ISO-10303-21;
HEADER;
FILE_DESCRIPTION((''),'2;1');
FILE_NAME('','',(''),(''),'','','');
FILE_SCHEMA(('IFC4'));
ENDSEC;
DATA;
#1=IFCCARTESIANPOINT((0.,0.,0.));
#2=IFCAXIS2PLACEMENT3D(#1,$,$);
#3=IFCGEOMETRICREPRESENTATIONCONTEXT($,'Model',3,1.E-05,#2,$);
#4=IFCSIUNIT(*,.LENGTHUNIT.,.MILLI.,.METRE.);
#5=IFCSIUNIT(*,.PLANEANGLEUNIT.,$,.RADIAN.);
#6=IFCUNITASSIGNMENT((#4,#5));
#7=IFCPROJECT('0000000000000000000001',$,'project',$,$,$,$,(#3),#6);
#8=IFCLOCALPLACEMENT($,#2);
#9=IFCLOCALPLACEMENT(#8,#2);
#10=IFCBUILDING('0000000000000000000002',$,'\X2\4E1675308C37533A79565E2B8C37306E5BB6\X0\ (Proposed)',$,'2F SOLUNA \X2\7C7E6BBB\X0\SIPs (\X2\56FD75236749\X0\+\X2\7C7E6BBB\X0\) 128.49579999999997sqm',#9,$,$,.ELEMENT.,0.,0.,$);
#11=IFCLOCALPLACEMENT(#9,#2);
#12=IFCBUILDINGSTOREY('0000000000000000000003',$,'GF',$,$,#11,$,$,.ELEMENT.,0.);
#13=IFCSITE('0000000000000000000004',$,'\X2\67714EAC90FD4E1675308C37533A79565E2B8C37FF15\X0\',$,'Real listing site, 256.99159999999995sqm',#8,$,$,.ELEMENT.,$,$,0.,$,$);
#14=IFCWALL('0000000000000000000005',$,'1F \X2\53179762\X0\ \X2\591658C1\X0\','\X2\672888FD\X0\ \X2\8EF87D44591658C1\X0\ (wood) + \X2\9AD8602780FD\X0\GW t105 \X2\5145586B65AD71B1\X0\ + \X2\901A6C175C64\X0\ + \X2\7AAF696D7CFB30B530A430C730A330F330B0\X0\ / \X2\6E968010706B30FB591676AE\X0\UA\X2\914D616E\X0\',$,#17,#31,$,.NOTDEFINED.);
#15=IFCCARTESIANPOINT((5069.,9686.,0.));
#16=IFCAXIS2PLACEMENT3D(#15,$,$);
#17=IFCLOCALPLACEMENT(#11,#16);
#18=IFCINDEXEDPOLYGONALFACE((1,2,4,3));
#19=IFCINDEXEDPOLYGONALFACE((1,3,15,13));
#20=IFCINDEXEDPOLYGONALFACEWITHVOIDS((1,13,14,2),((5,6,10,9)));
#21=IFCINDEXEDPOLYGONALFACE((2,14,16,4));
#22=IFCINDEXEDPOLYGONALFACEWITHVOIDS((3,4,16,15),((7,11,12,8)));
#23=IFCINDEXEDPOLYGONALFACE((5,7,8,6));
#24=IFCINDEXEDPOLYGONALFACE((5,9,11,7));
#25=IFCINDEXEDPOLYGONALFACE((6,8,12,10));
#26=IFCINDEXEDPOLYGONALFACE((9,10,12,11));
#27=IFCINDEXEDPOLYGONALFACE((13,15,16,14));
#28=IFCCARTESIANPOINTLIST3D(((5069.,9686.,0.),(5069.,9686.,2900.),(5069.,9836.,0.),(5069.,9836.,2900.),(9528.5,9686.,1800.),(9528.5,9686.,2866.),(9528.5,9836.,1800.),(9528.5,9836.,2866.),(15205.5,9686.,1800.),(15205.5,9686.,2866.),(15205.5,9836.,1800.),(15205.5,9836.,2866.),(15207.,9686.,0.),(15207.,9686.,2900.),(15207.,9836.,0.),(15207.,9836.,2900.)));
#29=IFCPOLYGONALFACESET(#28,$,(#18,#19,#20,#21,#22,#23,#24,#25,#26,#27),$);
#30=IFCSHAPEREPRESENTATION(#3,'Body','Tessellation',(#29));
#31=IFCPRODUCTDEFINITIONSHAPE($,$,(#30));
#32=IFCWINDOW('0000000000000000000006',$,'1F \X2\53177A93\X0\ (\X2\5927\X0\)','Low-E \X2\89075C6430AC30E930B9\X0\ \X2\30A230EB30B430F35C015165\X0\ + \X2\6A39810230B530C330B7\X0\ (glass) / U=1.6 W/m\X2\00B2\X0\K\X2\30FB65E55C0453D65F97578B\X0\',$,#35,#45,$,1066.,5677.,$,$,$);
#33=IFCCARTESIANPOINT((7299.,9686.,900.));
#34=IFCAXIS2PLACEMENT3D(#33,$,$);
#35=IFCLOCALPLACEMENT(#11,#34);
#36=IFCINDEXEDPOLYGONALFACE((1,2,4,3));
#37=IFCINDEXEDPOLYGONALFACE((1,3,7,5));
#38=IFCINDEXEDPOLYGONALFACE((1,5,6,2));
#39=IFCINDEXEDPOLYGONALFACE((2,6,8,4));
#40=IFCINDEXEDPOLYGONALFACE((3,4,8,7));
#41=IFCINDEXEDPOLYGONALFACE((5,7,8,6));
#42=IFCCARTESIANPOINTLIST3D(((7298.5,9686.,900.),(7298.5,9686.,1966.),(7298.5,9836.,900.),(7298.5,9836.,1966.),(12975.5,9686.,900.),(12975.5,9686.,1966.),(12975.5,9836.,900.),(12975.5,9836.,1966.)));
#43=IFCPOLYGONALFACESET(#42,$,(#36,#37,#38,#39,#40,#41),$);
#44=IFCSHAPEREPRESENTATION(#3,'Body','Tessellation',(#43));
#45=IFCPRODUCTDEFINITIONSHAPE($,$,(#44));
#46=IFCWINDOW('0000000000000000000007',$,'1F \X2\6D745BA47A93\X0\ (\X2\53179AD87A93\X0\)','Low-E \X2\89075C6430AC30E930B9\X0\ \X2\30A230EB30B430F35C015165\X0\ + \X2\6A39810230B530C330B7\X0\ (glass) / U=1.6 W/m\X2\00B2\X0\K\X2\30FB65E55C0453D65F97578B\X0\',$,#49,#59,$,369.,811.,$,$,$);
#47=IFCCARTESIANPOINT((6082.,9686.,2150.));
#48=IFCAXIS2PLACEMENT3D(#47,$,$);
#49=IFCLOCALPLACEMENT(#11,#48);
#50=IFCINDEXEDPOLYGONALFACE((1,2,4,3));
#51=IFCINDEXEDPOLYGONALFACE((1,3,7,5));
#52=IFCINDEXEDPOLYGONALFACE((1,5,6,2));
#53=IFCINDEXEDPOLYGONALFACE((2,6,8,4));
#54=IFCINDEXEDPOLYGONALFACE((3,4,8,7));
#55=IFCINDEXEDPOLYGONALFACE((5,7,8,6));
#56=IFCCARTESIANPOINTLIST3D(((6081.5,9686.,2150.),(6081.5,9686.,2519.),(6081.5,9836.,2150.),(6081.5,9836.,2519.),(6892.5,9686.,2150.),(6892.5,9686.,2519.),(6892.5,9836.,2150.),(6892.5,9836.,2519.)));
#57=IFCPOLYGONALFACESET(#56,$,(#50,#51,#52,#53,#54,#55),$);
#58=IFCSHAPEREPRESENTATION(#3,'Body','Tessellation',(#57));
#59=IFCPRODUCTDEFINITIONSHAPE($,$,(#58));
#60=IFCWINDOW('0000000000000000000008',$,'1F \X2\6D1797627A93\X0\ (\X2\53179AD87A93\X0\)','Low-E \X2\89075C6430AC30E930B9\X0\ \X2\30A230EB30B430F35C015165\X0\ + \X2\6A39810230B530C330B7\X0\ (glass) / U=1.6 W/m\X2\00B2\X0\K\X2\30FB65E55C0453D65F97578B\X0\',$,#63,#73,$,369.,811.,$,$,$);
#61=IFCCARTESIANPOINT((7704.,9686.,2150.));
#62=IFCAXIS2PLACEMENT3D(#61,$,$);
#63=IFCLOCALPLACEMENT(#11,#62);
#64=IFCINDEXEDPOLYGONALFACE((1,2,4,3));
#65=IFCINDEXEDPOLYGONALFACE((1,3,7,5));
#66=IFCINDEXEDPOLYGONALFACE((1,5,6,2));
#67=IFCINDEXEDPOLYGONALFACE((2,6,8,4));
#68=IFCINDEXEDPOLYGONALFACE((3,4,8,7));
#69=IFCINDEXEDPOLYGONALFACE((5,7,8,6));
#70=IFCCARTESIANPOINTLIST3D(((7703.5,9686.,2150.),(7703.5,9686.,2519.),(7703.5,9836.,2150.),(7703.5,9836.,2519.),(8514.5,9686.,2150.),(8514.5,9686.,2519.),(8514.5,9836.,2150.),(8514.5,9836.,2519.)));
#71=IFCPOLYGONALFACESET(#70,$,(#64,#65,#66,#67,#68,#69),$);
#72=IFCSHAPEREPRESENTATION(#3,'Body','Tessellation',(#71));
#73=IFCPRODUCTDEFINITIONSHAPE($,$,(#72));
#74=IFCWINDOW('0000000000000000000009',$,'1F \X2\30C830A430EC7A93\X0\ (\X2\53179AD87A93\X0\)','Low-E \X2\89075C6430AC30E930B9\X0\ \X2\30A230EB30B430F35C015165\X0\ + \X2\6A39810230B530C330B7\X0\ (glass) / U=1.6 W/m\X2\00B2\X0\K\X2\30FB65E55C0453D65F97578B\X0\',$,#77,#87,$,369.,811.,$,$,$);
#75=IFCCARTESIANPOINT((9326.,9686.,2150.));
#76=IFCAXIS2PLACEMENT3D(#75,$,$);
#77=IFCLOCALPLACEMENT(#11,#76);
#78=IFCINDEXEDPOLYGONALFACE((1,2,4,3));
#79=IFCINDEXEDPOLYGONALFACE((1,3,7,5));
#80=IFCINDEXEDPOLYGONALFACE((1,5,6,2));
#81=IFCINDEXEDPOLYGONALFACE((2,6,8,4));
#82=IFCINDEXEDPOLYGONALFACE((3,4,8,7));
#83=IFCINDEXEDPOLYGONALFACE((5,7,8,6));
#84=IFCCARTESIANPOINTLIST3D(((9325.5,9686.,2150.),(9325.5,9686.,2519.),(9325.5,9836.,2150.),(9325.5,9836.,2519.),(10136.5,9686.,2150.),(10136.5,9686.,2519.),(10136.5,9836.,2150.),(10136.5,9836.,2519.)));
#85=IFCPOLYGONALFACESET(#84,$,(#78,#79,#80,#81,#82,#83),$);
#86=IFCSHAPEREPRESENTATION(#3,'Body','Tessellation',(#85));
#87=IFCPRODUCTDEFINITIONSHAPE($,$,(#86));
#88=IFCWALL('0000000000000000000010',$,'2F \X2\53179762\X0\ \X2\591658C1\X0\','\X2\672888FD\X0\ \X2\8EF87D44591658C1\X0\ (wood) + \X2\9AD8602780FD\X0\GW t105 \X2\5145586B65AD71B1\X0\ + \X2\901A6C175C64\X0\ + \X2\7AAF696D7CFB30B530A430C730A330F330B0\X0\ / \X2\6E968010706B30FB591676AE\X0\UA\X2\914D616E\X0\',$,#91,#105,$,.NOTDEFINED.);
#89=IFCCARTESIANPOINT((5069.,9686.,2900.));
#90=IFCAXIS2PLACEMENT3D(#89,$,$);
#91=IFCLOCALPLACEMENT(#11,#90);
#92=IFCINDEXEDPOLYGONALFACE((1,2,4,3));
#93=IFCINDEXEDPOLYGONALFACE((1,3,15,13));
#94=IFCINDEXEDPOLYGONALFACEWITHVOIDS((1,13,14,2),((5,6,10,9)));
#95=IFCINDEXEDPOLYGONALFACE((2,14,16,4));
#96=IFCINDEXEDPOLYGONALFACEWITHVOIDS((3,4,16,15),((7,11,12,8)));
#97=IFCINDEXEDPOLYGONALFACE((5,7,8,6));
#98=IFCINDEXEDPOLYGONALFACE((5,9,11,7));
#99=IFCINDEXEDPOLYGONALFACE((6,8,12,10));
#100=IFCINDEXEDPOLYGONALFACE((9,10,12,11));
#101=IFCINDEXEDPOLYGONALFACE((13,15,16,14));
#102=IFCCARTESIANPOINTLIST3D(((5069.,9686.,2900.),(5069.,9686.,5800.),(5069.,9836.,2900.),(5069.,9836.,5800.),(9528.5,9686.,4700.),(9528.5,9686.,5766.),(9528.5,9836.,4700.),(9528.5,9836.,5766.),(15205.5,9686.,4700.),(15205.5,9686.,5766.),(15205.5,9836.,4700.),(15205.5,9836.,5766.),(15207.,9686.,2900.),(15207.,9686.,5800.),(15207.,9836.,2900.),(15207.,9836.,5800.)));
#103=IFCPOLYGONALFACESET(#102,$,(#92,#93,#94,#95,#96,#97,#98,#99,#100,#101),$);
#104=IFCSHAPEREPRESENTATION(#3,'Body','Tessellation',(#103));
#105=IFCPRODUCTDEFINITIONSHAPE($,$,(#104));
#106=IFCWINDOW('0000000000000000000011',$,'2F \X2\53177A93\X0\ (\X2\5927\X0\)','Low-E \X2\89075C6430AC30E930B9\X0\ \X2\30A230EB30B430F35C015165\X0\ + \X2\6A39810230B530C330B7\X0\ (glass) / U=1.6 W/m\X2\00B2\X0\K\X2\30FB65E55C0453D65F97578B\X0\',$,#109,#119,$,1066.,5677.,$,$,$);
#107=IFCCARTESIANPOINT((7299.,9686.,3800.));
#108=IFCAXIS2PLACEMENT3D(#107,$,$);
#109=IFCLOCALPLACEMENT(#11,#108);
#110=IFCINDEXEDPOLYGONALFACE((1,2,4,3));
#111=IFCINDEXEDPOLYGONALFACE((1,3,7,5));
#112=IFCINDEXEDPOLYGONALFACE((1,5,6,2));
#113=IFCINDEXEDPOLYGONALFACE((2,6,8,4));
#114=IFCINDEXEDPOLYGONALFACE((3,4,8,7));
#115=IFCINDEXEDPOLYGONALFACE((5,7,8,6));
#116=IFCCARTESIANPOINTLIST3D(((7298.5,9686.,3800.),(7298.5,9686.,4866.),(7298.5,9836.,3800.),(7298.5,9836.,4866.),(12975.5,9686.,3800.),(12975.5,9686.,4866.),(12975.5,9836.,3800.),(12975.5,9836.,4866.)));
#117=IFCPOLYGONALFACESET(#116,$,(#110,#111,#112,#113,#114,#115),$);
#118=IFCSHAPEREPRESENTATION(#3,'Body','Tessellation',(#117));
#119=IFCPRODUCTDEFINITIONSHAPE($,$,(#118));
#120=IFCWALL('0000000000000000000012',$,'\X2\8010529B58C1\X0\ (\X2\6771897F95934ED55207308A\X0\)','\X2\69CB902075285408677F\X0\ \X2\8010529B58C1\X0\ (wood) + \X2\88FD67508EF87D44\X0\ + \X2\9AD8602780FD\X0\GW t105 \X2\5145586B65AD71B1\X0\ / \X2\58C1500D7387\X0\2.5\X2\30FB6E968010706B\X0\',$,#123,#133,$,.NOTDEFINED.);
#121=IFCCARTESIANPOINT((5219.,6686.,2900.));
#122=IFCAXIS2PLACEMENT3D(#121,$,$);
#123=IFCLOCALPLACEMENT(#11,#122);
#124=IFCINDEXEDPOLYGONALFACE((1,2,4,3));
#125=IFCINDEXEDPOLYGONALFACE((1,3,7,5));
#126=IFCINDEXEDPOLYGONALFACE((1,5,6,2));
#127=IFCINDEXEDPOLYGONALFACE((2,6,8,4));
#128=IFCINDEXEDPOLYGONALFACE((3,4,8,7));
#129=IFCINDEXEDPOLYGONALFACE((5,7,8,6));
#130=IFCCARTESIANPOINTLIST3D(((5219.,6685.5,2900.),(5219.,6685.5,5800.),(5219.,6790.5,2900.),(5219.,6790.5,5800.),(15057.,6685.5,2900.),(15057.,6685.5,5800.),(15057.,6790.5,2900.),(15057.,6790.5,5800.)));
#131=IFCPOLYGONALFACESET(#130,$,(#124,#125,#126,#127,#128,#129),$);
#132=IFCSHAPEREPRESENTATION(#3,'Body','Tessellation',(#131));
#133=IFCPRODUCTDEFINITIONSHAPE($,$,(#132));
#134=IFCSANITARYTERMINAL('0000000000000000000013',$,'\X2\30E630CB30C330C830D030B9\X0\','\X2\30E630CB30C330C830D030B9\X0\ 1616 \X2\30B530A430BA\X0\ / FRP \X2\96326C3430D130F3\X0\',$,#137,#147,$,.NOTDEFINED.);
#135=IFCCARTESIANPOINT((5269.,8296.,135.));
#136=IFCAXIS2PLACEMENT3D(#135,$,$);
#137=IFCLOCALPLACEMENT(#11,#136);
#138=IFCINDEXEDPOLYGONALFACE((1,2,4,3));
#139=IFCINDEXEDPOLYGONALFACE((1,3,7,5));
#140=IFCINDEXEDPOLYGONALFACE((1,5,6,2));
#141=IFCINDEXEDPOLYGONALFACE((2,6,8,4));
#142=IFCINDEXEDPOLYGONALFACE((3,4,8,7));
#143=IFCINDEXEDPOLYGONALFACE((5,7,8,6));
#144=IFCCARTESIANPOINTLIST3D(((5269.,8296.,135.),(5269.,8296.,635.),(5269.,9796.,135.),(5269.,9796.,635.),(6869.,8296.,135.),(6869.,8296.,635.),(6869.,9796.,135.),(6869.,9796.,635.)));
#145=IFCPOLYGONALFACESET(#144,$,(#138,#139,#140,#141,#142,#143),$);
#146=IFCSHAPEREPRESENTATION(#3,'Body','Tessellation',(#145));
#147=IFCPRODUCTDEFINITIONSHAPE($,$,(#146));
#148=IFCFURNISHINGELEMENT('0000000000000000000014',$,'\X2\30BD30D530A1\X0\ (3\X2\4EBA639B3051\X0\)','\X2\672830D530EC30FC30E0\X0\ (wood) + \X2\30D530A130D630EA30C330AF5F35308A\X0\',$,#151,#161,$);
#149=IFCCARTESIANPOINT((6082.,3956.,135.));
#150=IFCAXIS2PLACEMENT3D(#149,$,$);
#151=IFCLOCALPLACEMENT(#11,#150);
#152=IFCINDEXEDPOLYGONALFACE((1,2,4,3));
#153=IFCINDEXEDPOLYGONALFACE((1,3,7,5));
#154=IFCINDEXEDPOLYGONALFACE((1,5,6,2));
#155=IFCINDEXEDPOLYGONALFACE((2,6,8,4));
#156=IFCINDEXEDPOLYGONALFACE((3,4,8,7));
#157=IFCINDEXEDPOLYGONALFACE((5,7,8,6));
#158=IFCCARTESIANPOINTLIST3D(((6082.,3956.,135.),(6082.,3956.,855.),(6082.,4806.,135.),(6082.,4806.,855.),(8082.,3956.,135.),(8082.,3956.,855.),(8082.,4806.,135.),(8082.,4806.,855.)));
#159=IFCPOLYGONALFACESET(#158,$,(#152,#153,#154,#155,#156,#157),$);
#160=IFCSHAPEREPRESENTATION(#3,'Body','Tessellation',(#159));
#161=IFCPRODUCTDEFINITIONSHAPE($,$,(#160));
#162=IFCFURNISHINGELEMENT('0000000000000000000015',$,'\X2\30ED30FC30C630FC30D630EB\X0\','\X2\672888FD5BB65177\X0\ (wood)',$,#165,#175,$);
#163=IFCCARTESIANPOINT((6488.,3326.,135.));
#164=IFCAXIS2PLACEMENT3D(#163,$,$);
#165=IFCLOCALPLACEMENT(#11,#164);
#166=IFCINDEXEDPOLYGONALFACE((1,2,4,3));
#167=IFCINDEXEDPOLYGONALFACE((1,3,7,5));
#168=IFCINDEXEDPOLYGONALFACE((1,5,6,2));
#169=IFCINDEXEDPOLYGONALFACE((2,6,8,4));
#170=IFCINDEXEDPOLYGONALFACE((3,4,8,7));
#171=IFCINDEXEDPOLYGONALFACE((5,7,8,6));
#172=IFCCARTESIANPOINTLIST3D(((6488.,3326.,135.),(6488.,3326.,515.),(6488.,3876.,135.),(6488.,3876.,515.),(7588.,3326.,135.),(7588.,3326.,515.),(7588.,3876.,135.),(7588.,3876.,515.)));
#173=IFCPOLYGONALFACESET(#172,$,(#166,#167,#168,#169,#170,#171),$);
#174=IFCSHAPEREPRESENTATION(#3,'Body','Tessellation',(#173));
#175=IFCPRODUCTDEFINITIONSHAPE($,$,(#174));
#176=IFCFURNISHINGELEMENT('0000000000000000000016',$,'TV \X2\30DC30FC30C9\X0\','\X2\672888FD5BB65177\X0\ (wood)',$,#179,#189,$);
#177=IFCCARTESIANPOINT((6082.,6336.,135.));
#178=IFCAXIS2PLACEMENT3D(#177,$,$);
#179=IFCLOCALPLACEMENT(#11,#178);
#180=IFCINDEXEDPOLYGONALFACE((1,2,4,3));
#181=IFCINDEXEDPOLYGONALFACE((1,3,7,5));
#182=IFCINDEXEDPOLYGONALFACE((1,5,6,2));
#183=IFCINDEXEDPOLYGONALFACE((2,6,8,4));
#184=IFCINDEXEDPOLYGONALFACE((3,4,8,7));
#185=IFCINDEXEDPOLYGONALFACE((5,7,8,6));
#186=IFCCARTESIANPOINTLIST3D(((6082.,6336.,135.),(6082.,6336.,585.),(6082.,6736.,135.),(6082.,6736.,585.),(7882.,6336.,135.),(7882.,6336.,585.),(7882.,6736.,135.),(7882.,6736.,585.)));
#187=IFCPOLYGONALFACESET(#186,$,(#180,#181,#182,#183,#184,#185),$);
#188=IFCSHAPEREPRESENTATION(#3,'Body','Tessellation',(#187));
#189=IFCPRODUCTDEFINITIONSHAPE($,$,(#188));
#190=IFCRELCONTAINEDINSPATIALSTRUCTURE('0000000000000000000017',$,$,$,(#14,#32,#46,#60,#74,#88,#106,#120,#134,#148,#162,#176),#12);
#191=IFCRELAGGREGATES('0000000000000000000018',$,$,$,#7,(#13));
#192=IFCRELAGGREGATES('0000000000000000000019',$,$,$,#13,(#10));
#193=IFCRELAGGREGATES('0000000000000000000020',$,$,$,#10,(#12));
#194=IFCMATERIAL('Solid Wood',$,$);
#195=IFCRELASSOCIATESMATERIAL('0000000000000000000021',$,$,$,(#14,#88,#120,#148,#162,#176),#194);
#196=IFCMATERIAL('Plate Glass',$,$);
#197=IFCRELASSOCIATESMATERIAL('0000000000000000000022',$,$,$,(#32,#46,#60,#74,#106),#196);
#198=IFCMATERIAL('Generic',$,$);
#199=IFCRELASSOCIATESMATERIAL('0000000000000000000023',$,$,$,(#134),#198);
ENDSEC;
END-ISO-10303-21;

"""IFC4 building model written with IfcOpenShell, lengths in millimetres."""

from ifc_helpers import new_model, si_unit, frame, frame_2d, origin, place, context, project, spatial, rectangle, extrude, material, element, fill, save


model = new_model("IFC4")

# Units and contexts
model_context = context("Model", 3, precision=1e-05, world=origin())
ifc_project = project(units=[si_unit("LENGTHUNIT", "METRE", prefix="MILLI"), si_unit("PLANEANGLEUNIT", "RADIAN")], contexts=[model_context])

# Site, building, storey
site_placement = place(None, origin())
site = spatial("IfcSite", under=ifc_project, at=site_placement, Name="東京都世田谷区祖師谷５", ObjectType="Real listing site, 256.99159999999995sqm", CompositionType="ELEMENT", RefElevation=0.0)
building_placement = place(site_placement, origin())
building = spatial("IfcBuilding", under=site, at=building_placement, Name="世田谷区祖師谷の家 (Proposed)", ObjectType="2F SOLUNA 籾殻SIPs (国産杉+籾殻) 128.49579999999997sqm", CompositionType="ELEMENT", ElevationOfRefHeight=0.0, ElevationOfTerrain=0.0)
storey_placement = place(building_placement, origin())
storey = spatial("IfcBuildingStorey", under=building, at=storey_placement, Name="GF", CompositionType="ELEMENT", Elevation=0.0)

# Wall, openings, windows
ifc_material_1 = material(Name="Solid Wood")
wall_1_placement = place(storey_placement, frame((5069.0, 9686.0, 0.0)))
wall_1 = element("IfcWall", 1, at=wall_1_placement, inside=storey, material=ifc_material_1, Name="1F 北面 外壁", Description="木製 軸組外壁 (wood) + 高性能GW t105 充填断熱 + 通気層 + 窯業系サイディング / 準耐火・外皮UA配慮", PredefinedType="NOTDEFINED", context=model_context, shape_type="SweptSolid", body=[
    extrude(rectangle(XDim=10138.0, YDim=150.0, at=frame_2d((5069.0, 75.0))), frame((5069.0, 9686.0, 0.0)), (0.0, 0.0, 1.0), 2900.0),
])
opening_1_placement = place(storey_placement, frame((7299.0, 9686.0, 900.0)))
opening_1 = element("IfcOpeningElement", 2, at=opening_1_placement, cuts=wall_1, PredefinedType="NOTDEFINED", context=model_context, shape_type="SweptSolid", body=[
    extrude(rectangle(XDim=5677.0, YDim=150.0, at=frame_2d((2838.0, 75.0))), frame((7299.0, 9686.0, 900.0)), (0.0, 0.0, 1.0), 1066.0),
])
opening_2_placement = place(storey_placement, frame((6082.0, 9686.0, 2150.0)))
opening_2 = element("IfcOpeningElement", 3, at=opening_2_placement, cuts=wall_1, PredefinedType="NOTDEFINED", context=model_context, shape_type="SweptSolid", body=[
    extrude(rectangle(XDim=811.0, YDim=150.0, at=frame_2d((405.0, 75.0))), frame((6082.0, 9686.0, 2150.0)), (0.0, 0.0, 1.0), 369.0),
])
opening_3_placement = place(storey_placement, frame((7704.0, 9686.0, 2150.0)))
opening_3 = element("IfcOpeningElement", 4, at=opening_3_placement, cuts=wall_1, PredefinedType="NOTDEFINED", context=model_context, shape_type="SweptSolid", body=[
    extrude(rectangle(XDim=811.0, YDim=150.0, at=frame_2d((405.0, 75.0))), frame((7704.0, 9686.0, 2150.0)), (0.0, 0.0, 1.0), 369.0),
])
opening_4_placement = place(storey_placement, frame((9326.0, 9686.0, 2150.0)))
opening_4 = element("IfcOpeningElement", 5, at=opening_4_placement, cuts=wall_1, PredefinedType="NOTDEFINED", context=model_context, shape_type="SweptSolid", body=[
    extrude(rectangle(XDim=811.0, YDim=150.0, at=frame_2d((405.0, 75.0))), frame((9326.0, 9686.0, 2150.0)), (0.0, 0.0, 1.0), 369.0),
])
ifc_material_2 = material(Name="Plate Glass")
window_1_placement = place(storey_placement, frame((7299.0, 9686.0, 900.0)))
window_1 = element("IfcWindow", 6, at=window_1_placement, inside=storey, material=ifc_material_2, Name="1F 北窓 (大)", Description="Low-E 複層ガラス アルゴン封入 + 樹脂サッシ (glass) / U=1.6 W/m²K・日射取得型", OverallHeight=1066.0, OverallWidth=5677.0, context=model_context, shape_type="SweptSolid", body=[
    extrude(rectangle(XDim=5677.0, YDim=150.0, at=frame_2d((2838.0, 75.0))), frame((7299.0, 9686.0, 900.0)), (0.0, 0.0, 1.0), 1066.0),
])
fill(opening_1, window_1)
window_2_placement = place(storey_placement, frame((6082.0, 9686.0, 2150.0)))
window_2 = element("IfcWindow", 7, at=window_2_placement, inside=storey, material=ifc_material_2, Name="1F 浴室窓 (北高窓)", Description="Low-E 複層ガラス アルゴン封入 + 樹脂サッシ (glass) / U=1.6 W/m²K・日射取得型", OverallHeight=369.0, OverallWidth=811.0, context=model_context, shape_type="SweptSolid", body=[
    extrude(rectangle(XDim=811.0, YDim=150.0, at=frame_2d((405.0, 75.0))), frame((6082.0, 9686.0, 2150.0)), (0.0, 0.0, 1.0), 369.0),
])
fill(opening_2, window_2)
window_3_placement = place(storey_placement, frame((7704.0, 9686.0, 2150.0)))
window_3 = element("IfcWindow", 8, at=window_3_placement, inside=storey, material=ifc_material_2, Name="1F 洗面窓 (北高窓)", Description="Low-E 複層ガラス アルゴン封入 + 樹脂サッシ (glass) / U=1.6 W/m²K・日射取得型", OverallHeight=369.0, OverallWidth=811.0, context=model_context, shape_type="SweptSolid", body=[
    extrude(rectangle(XDim=811.0, YDim=150.0, at=frame_2d((405.0, 75.0))), frame((7704.0, 9686.0, 2150.0)), (0.0, 0.0, 1.0), 369.0),
])
fill(opening_3, window_3)
window_4_placement = place(storey_placement, frame((9326.0, 9686.0, 2150.0)))
window_4 = element("IfcWindow", 9, at=window_4_placement, inside=storey, material=ifc_material_2, Name="1F トイレ窓 (北高窓)", Description="Low-E 複層ガラス アルゴン封入 + 樹脂サッシ (glass) / U=1.6 W/m²K・日射取得型", OverallHeight=369.0, OverallWidth=811.0, context=model_context, shape_type="SweptSolid", body=[
    extrude(rectangle(XDim=811.0, YDim=150.0, at=frame_2d((405.0, 75.0))), frame((9326.0, 9686.0, 2150.0)), (0.0, 0.0, 1.0), 369.0),
])
fill(opening_4, window_4)

# Wall, opening, window
wall_2_placement = place(storey_placement, frame((5069.0, 9686.0, 2900.0)))
wall_2 = element("IfcWall", 10, at=wall_2_placement, inside=storey, material=ifc_material_1, Name="2F 北面 外壁", Description="木製 軸組外壁 (wood) + 高性能GW t105 充填断熱 + 通気層 + 窯業系サイディング / 準耐火・外皮UA配慮", PredefinedType="NOTDEFINED", context=model_context, shape_type="SweptSolid", body=[
    extrude(rectangle(XDim=10138.0, YDim=150.0, at=frame_2d((5069.0, 75.0))), frame((5069.0, 9686.0, 2900.0)), (0.0, 0.0, 1.0), 2900.0),
])
opening_5_placement = place(storey_placement, frame((7299.0, 9686.0, 3800.0)))
opening_5 = element("IfcOpeningElement", 11, at=opening_5_placement, cuts=wall_2, PredefinedType="NOTDEFINED", context=model_context, shape_type="SweptSolid", body=[
    extrude(rectangle(XDim=5677.0, YDim=150.0, at=frame_2d((2838.0, 75.0))), frame((7299.0, 9686.0, 3800.0)), (0.0, 0.0, 1.0), 1066.0),
])
window_5_placement = place(storey_placement, frame((7299.0, 9686.0, 3800.0)))
window_5 = element("IfcWindow", 12, at=window_5_placement, inside=storey, material=ifc_material_2, Name="2F 北窓 (大)", Description="Low-E 複層ガラス アルゴン封入 + 樹脂サッシ (glass) / U=1.6 W/m²K・日射取得型", OverallHeight=1066.0, OverallWidth=5677.0, context=model_context, shape_type="SweptSolid", body=[
    extrude(rectangle(XDim=5677.0, YDim=150.0, at=frame_2d((2838.0, 75.0))), frame((7299.0, 9686.0, 3800.0)), (0.0, 0.0, 1.0), 1066.0),
])
fill(opening_5, window_5)

# Wall
wall_3_placement = place(storey_placement, frame((5219.0, 6686.0, 2900.0)))
element("IfcWall", 13, at=wall_3_placement, inside=storey, material=ifc_material_1, Name="耐力壁 (東西間仕切り)", Description="構造用合板 耐力壁 (wood) + 製材軸組 + 高性能GW t105 充填断熱 / 壁倍率2.5・準耐火", PredefinedType="NOTDEFINED", context=model_context, shape_type="SweptSolid", body=[
    extrude(rectangle(XDim=9838.0, YDim=105.0, at=frame_2d((4919.0, 52.0))), frame((5219.0, 6686.0, 2900.0)), (0.0, 0.0, 1.0), 2900.0),
])

# Sanitary terminal
ifc_material_3 = material(Name="Generic")
sanitary_terminal_placement = place(storey_placement, frame((5269.0, 8296.0, 135.0)))
element("IfcSanitaryTerminal", 14, at=sanitary_terminal_placement, inside=storey, material=ifc_material_3, Name="ユニットバス", Description="ユニットバス 1616 サイズ / FRP 防水パン", PredefinedType="NOTDEFINED", context=model_context, shape_type="SweptSolid", body=[
    extrude(rectangle(XDim=1600.0, YDim=1500.0, at=frame_2d((800.0, 750.0))), frame((5269.0, 8296.0, 135.0)), (0.0, 0.0, 1.0), 500.0),
])

# Furnishing elements
furnishing_1_placement = place(storey_placement, frame((6082.0, 3956.0, 135.0)))
element("IfcFurnishingElement", 15, at=furnishing_1_placement, inside=storey, material=ifc_material_1, Name="ソファ (3人掛け)", Description="木フレーム (wood) + ファブリック張り", context=model_context, shape_type="SweptSolid", body=[
    extrude(rectangle(XDim=2000.0, YDim=850.0, at=frame_2d((1000.0, 425.0))), frame((6082.0, 3956.0, 135.0)), (0.0, 0.0, 1.0), 720.0),
])
furnishing_2_placement = place(storey_placement, frame((6488.0, 3326.0, 135.0)))
element("IfcFurnishingElement", 16, at=furnishing_2_placement, inside=storey, material=ifc_material_1, Name="ローテーブル", Description="木製家具 (wood)", context=model_context, shape_type="SweptSolid", body=[
    extrude(rectangle(XDim=1100.0, YDim=550.0, at=frame_2d((550.0, 275.0))), frame((6488.0, 3326.0, 135.0)), (0.0, 0.0, 1.0), 380.0),
])
furnishing_3_placement = place(storey_placement, frame((6082.0, 6336.0, 135.0)))
element("IfcFurnishingElement", 17, at=furnishing_3_placement, inside=storey, material=ifc_material_1, Name="TV ボード", Description="木製家具 (wood)", context=model_context, shape_type="SweptSolid", body=[
    extrude(rectangle(XDim=1800.0, YDim=400.0, at=frame_2d((900.0, 200.0))), frame((6082.0, 6336.0, 135.0)), (0.0, 0.0, 1.0), 450.0),
])

save(model, "model.ifc")
